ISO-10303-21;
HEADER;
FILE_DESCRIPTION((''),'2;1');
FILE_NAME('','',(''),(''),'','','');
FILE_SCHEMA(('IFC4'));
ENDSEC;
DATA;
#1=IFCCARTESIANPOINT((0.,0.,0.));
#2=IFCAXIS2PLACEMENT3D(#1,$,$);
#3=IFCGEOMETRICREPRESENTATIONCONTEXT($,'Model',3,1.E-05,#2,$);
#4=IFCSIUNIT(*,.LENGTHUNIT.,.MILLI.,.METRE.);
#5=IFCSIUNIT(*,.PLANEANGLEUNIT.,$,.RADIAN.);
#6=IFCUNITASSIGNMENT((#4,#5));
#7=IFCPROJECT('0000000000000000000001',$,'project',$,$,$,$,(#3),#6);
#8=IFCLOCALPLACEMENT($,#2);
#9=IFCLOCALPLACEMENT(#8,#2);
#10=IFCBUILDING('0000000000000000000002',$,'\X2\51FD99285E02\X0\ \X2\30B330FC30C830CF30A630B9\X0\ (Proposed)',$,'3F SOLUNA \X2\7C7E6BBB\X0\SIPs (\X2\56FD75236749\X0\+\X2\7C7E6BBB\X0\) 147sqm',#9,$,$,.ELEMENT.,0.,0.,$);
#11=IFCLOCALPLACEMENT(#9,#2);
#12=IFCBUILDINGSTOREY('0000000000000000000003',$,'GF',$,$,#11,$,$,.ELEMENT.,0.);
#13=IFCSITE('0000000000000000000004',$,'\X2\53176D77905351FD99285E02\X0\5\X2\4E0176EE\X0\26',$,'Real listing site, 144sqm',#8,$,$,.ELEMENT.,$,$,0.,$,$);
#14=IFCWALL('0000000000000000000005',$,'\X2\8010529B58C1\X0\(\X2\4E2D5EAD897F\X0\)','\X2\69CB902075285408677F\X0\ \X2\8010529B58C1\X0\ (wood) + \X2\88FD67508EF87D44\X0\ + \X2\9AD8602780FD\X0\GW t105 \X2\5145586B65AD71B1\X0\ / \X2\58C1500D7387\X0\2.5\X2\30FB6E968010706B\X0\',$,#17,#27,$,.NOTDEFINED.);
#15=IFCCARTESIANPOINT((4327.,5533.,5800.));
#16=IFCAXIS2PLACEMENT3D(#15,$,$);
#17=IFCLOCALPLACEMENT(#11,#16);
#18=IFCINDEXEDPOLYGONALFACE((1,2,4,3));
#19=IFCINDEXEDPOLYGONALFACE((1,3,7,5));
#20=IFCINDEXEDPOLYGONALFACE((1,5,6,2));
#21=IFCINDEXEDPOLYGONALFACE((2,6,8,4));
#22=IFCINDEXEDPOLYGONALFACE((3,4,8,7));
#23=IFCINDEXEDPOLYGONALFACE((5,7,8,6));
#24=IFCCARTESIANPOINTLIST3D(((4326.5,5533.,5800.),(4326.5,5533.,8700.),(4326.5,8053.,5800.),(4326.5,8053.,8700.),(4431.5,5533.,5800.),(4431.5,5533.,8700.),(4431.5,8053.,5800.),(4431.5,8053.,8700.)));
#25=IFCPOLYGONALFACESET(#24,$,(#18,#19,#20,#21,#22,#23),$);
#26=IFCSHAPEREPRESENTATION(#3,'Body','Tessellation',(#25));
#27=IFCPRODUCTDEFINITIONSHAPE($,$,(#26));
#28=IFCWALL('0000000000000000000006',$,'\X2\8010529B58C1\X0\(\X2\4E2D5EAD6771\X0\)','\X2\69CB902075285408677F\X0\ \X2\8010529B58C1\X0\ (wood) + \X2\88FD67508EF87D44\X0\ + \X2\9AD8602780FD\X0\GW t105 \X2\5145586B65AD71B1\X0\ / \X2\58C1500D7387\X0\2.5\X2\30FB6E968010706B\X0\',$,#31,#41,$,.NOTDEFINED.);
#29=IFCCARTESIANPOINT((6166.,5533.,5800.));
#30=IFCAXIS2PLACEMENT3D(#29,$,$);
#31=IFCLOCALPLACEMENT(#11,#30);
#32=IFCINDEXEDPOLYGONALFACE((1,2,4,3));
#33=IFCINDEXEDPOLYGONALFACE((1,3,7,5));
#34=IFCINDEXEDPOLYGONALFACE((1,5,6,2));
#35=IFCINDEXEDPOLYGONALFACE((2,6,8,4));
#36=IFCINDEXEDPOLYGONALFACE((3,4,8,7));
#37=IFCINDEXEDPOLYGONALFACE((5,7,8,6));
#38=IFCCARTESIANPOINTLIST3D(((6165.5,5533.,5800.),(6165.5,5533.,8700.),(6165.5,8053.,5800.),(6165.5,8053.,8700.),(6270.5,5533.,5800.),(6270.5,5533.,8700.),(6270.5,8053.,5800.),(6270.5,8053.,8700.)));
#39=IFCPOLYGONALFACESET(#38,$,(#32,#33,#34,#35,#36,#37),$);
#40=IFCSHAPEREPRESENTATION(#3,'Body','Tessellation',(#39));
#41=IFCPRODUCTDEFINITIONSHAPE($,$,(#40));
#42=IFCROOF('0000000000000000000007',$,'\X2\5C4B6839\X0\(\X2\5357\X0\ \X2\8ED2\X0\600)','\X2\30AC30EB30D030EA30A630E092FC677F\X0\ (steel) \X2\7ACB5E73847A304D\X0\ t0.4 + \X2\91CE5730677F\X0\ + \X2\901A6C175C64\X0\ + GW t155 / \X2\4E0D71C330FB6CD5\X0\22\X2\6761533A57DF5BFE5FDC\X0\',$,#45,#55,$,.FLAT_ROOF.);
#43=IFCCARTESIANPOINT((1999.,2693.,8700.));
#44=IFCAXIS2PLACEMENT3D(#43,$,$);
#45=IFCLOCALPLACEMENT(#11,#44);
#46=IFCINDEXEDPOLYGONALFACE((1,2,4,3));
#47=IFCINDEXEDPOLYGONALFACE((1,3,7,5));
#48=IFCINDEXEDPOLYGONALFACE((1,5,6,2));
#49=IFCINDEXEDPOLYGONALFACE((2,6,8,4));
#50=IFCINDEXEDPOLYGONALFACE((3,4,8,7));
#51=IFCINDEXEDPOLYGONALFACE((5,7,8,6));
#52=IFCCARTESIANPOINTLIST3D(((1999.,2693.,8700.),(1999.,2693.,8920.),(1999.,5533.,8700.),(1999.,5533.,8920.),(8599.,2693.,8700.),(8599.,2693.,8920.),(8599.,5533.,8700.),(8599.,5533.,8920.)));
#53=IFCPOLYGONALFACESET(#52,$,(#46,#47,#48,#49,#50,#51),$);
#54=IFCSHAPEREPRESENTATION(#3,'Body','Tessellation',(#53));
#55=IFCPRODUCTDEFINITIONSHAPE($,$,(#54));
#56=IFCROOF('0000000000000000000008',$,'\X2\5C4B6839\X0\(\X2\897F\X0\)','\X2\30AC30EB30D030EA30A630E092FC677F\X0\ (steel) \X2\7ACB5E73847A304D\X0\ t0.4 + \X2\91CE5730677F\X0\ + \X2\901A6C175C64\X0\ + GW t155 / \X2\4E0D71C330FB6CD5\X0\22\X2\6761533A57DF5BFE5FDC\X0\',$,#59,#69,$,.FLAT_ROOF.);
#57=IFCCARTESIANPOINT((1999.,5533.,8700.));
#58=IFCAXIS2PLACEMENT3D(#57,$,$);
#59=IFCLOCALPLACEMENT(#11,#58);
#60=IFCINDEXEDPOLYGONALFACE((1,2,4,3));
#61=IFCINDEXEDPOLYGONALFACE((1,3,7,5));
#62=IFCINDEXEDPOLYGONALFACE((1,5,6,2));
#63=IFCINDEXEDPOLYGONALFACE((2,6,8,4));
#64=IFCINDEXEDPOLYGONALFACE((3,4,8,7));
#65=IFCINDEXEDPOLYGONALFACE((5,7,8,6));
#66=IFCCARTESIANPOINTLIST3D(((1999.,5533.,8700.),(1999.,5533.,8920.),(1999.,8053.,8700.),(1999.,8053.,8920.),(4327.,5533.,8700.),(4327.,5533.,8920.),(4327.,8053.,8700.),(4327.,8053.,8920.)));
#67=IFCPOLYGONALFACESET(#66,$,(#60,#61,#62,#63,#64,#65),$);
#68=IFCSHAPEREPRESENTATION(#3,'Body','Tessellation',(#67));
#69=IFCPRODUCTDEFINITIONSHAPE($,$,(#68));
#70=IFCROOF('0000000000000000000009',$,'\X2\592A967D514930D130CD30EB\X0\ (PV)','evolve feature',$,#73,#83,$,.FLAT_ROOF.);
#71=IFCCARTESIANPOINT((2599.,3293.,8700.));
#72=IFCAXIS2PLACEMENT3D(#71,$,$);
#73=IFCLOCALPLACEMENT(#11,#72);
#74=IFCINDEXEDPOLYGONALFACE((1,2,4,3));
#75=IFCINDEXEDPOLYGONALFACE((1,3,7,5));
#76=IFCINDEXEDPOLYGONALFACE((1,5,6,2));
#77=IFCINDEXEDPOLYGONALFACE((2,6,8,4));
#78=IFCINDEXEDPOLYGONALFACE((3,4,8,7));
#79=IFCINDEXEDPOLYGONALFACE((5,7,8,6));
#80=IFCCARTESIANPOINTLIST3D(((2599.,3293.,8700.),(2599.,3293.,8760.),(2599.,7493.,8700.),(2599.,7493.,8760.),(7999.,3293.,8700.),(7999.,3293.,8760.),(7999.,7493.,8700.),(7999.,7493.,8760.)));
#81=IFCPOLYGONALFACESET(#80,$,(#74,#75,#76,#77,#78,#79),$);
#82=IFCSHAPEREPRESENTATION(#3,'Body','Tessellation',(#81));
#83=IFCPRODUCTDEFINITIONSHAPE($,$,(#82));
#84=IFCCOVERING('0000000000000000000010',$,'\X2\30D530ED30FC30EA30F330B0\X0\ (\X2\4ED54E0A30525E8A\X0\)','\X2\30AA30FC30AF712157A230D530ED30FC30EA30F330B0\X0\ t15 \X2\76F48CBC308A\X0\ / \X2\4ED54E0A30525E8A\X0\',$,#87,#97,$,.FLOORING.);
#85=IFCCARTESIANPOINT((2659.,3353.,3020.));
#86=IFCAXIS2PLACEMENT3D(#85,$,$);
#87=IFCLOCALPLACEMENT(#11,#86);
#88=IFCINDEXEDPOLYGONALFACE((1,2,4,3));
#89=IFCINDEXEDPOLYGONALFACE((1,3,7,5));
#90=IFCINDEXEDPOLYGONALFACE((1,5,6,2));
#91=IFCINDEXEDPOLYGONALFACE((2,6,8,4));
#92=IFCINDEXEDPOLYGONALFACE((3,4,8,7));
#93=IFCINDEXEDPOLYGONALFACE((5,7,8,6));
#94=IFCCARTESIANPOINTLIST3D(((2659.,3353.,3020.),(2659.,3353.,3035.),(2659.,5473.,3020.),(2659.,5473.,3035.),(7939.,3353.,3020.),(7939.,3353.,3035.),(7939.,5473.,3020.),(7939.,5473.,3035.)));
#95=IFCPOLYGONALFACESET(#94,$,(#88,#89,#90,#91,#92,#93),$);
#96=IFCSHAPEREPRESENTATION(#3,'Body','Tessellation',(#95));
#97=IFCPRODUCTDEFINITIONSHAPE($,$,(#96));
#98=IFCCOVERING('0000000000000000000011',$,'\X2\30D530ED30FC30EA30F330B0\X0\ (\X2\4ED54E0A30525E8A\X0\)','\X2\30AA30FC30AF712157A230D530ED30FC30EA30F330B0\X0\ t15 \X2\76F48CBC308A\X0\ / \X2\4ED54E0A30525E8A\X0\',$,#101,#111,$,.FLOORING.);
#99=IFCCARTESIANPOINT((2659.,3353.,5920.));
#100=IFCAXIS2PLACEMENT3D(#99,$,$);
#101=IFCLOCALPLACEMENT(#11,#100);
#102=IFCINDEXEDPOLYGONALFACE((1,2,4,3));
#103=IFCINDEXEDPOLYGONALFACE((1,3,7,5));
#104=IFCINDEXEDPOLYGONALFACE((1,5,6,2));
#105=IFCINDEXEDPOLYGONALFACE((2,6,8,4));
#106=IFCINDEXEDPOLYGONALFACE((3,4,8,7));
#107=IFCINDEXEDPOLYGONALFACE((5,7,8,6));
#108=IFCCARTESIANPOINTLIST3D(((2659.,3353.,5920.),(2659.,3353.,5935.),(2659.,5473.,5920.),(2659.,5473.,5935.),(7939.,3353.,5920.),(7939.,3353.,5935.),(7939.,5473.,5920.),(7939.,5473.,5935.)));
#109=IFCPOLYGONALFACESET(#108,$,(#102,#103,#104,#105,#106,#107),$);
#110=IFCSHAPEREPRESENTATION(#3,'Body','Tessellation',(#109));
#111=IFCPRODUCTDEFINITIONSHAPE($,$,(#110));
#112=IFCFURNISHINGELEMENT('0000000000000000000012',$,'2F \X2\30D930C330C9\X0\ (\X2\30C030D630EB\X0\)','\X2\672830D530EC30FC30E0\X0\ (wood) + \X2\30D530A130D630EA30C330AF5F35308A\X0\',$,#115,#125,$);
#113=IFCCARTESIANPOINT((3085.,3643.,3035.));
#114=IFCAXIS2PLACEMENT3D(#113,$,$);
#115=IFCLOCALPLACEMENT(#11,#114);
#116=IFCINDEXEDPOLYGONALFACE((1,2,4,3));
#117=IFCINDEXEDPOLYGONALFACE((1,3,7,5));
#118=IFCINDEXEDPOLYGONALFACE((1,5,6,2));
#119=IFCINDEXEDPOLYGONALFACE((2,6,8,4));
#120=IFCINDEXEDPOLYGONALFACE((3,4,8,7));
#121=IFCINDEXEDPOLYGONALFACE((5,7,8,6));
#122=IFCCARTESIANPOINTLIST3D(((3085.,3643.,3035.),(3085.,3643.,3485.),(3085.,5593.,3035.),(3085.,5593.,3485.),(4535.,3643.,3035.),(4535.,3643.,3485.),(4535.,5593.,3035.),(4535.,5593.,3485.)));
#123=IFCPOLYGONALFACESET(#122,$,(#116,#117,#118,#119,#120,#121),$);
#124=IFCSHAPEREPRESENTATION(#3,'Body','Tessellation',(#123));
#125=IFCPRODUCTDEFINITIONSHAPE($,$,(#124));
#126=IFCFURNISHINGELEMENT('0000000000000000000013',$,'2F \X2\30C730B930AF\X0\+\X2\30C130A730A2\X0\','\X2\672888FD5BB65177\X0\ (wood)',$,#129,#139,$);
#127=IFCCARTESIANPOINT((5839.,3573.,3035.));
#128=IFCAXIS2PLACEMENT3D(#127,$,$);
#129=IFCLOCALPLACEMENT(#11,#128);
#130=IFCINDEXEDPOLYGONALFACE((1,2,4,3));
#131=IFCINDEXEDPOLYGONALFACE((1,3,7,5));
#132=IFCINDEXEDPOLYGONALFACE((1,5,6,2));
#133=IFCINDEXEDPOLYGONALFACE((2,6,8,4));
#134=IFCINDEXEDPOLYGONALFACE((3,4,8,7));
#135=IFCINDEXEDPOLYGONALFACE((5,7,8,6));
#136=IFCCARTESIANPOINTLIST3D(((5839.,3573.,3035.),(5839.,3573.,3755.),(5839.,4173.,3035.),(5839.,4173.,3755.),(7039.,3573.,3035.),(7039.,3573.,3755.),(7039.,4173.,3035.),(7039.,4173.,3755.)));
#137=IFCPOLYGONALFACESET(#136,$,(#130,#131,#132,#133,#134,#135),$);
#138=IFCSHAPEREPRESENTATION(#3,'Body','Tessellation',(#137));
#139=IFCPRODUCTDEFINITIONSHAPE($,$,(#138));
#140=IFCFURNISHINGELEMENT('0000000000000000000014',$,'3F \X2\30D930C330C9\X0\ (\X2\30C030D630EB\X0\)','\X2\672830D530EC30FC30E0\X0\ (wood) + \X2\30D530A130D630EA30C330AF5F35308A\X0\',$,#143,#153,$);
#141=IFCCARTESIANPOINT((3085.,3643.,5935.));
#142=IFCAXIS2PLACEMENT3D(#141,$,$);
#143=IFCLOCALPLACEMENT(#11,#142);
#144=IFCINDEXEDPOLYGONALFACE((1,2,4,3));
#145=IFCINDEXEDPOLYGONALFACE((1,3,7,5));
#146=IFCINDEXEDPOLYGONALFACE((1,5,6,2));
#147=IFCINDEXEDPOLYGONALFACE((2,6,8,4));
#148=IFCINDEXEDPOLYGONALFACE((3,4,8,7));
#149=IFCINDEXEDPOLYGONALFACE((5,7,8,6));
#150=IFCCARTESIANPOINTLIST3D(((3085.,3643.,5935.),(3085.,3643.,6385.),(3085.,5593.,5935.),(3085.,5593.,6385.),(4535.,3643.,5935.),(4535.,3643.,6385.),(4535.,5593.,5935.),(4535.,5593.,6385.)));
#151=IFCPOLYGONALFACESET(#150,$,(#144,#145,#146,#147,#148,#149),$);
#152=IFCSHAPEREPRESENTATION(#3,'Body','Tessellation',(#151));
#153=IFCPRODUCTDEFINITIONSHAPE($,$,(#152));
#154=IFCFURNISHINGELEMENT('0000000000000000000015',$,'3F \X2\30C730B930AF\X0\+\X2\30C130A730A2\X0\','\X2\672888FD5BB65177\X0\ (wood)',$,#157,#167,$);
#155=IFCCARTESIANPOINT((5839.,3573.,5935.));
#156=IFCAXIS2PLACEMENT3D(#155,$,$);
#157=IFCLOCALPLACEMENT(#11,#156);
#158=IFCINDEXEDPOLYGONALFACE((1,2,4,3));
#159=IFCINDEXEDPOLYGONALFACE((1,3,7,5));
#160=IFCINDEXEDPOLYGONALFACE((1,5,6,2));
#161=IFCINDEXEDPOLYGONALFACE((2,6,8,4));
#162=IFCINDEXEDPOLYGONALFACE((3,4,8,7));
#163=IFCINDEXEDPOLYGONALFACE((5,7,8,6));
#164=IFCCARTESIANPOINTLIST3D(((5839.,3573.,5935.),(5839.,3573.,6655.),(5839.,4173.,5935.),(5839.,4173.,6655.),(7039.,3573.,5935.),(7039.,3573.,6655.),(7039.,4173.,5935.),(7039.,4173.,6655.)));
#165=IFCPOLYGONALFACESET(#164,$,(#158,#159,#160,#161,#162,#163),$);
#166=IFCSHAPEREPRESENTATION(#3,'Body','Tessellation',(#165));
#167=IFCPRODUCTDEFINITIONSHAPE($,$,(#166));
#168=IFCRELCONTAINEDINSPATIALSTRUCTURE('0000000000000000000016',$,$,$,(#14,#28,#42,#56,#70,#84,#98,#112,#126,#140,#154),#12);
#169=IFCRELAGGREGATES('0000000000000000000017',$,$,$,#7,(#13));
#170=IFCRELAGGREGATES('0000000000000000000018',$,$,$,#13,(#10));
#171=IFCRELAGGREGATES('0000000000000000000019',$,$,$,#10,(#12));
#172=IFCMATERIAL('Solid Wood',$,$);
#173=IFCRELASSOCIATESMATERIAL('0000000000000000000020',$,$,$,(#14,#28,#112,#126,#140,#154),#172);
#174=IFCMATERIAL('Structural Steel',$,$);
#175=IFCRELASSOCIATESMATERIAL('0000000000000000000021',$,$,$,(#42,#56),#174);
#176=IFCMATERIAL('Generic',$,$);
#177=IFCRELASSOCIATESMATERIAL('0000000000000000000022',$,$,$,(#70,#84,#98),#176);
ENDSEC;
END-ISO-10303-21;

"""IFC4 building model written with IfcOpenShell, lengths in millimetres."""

from ifc_helpers import new_model, si_unit, frame, frame_2d, origin, place, context, project, spatial, rectangle, extrude, material, element, save


model = new_model("IFC4")

# Units and contexts
model_context = context("Model", 3, precision=1e-05, world=origin())
ifc_project = project(units=[si_unit("LENGTHUNIT", "METRE", prefix="MILLI"), si_unit("PLANEANGLEUNIT", "RADIAN")], contexts=[model_context])

# Site, building, storey
site_placement = place(None, origin())
site = spatial("IfcSite", under=ifc_project, at=site_placement, Name="北海道函館市5丁目26", ObjectType="Real listing site, 144sqm", CompositionType="ELEMENT", RefElevation=0.0)
building_placement = place(site_placement, origin())
building = spatial("IfcBuilding", under=site, at=building_placement, Name="函館市 コートハウス (Proposed)", ObjectType="3F SOLUNA 籾殻SIPs (国産杉+籾殻) 147sqm", CompositionType="ELEMENT", ElevationOfRefHeight=0.0, ElevationOfTerrain=0.0)
storey_placement = place(building_placement, origin())
storey = spatial("IfcBuildingStorey", under=building, at=storey_placement, Name="GF", CompositionType="ELEMENT", Elevation=0.0)

# Shared definitions
ifc_material_1 = material(Name="Solid Wood")

# Walls
wall_1_placement = place(storey_placement, frame((4327.0, 5533.0, 5800.0)))
element("IfcWall", 1, at=wall_1_placement, inside=storey, material=ifc_material_1, Name="耐力壁(中庭西)", Description="構造用合板 耐力壁 (wood) + 製材軸組 + 高性能GW t105 充填断熱 / 壁倍率2.5・準耐火", PredefinedType="NOTDEFINED", context=model_context, shape_type="SweptSolid", body=[
    extrude(rectangle(XDim=105.0, YDim=2520.0, at=frame_2d((52.0, 1260.0))), frame((4327.0, 5533.0, 5800.0)), (0.0, 0.0, 1.0), 2900.0),
])
wall_2_placement = place(storey_placement, frame((6166.0, 5533.0, 5800.0)))
element("IfcWall", 2, at=wall_2_placement, inside=storey, material=ifc_material_1, Name="耐力壁(中庭東)", Description="構造用合板 耐力壁 (wood) + 製材軸組 + 高性能GW t105 充填断熱 / 壁倍率2.5・準耐火", PredefinedType="NOTDEFINED", context=model_context, shape_type="SweptSolid", body=[
    extrude(rectangle(XDim=105.0, YDim=2520.0, at=frame_2d((52.0, 1260.0))), frame((6166.0, 5533.0, 5800.0)), (0.0, 0.0, 1.0), 2900.0),
])

# Roofs
ifc_material_2 = material(Name="Structural Steel")
roof_1_placement = place(storey_placement, frame((1999.0, 2693.0, 8700.0)))
element("IfcRoof", 3, at=roof_1_placement, inside=storey, material=ifc_material_2, Name="屋根(南 軒600)", Description="ガルバリウム鋼板 (steel) 立平葺き t0.4 + 野地板 + 通気層 + GW t155 / 不燃・法22条区域対応", PredefinedType="FLAT_ROOF", context=model_context, shape_type="SweptSolid", body=[
    extrude(rectangle(XDim=6600.0, YDim=2840.0, at=frame_2d((3300.0, 1420.0))), frame((1999.0, 2693.0, 8700.0)), (0.0, 0.0, 1.0), 220.0),
])
roof_2_placement = place(storey_placement, frame((1999.0, 5533.0, 8700.0)))
element("IfcRoof", 4, at=roof_2_placement, inside=storey, material=ifc_material_2, Name="屋根(西)", Description="ガルバリウム鋼板 (steel) 立平葺き t0.4 + 野地板 + 通気層 + GW t155 / 不燃・法22条区域対応", PredefinedType="FLAT_ROOF", context=model_context, shape_type="SweptSolid", body=[
    extrude(rectangle(XDim=2328.0, YDim=2520.0, at=frame_2d((1164.0, 1260.0))), frame((1999.0, 5533.0, 8700.0)), (0.0, 0.0, 1.0), 220.0),
])
ifc_material_3 = material(Name="Generic")
roof_3_placement = place(storey_placement, frame((2599.0, 3293.0, 8700.0)))
element("IfcRoof", 5, at=roof_3_placement, inside=storey, material=ifc_material_3, Name="太陽光パネル (PV)", Description="evolve feature", PredefinedType="FLAT_ROOF", context=model_context, shape_type="SweptSolid", body=[
    extrude(rectangle(XDim=5400.0, YDim=4200.0, at=frame_2d((2700.0, 2100.0))), frame((2599.0, 3293.0, 8700.0)), (0.0, 0.0, 1.0), 60.0),
])

# Coverings
covering_1_placement = place(storey_placement, frame((2659.0, 3353.0, 3020.0)))
element("IfcCovering", 6, at=covering_1_placement, inside=storey, material=ifc_material_3, Name="フローリング (仕上げ床)", Description="オーク無垢フローリング t15 直貼り / 仕上げ床", PredefinedType="FLOORING", context=model_context, shape_type="SweptSolid", body=[
    extrude(rectangle(XDim=5280.0, YDim=2120.0, at=frame_2d((2640.0, 1060.0))), frame((2659.0, 3353.0, 3020.0)), (0.0, 0.0, 1.0), 15.0),
])
covering_2_placement = place(storey_placement, frame((2659.0, 3353.0, 5920.0)))
element("IfcCovering", 7, at=covering_2_placement, inside=storey, material=ifc_material_3, Name="フローリング (仕上げ床)", Description="オーク無垢フローリング t15 直貼り / 仕上げ床", PredefinedType="FLOORING", context=model_context, shape_type="SweptSolid", body=[
    extrude(rectangle(XDim=5280.0, YDim=2120.0, at=frame_2d((2640.0, 1060.0))), frame((2659.0, 3353.0, 5920.0)), (0.0, 0.0, 1.0), 15.0),
])

# Furnishing elements
furnishing_1_placement = place(storey_placement, frame((3085.0, 3643.0, 3035.0)))
element("IfcFurnishingElement", 8, at=furnishing_1_placement, inside=storey, material=ifc_material_1, Name="2F ベッド (ダブル)", Description="木フレーム (wood) + ファブリック張り", context=model_context, shape_type="SweptSolid", body=[
    extrude(rectangle(XDim=1450.0, YDim=1950.0, at=frame_2d((725.0, 975.0))), frame((3085.0, 3643.0, 3035.0)), (0.0, 0.0, 1.0), 450.0),
])
furnishing_2_placement = place(storey_placement, frame((5839.0, 3573.0, 3035.0)))
element("IfcFurnishingElement", 9, at=furnishing_2_placement, inside=storey, material=ifc_material_1, Name="2F デスク+チェア", Description="木製家具 (wood)", context=model_context, shape_type="SweptSolid", body=[
    extrude(rectangle(XDim=1200.0, YDim=600.0, at=frame_2d((600.0, 300.0))), frame((5839.0, 3573.0, 3035.0)), (0.0, 0.0, 1.0), 720.0),
])
furnishing_3_placement = place(storey_placement, frame((3085.0, 3643.0, 5935.0)))
element("IfcFurnishingElement", 10, at=furnishing_3_placement, inside=storey, material=ifc_material_1, Name="3F ベッド (ダブル)", Description="木フレーム (wood) + ファブリック張り", context=model_context, shape_type="SweptSolid", body=[
    extrude(rectangle(XDim=1450.0, YDim=1950.0, at=frame_2d((725.0, 975.0))), frame((3085.0, 3643.0, 5935.0)), (0.0, 0.0, 1.0), 450.0),
])
furnishing_4_placement = place(storey_placement, frame((5839.0, 3573.0, 5935.0)))
element("IfcFurnishingElement", 11, at=furnishing_4_placement, inside=storey, material=ifc_material_1, Name="3F デスク+チェア", Description="木製家具 (wood)", context=model_context, shape_type="SweptSolid", body=[
    extrude(rectangle(XDim=1200.0, YDim=600.0, at=frame_2d((600.0, 300.0))), frame((5839.0, 3573.0, 5935.0)), (0.0, 0.0, 1.0), 720.0),
])

save(model, "model.ifc")
